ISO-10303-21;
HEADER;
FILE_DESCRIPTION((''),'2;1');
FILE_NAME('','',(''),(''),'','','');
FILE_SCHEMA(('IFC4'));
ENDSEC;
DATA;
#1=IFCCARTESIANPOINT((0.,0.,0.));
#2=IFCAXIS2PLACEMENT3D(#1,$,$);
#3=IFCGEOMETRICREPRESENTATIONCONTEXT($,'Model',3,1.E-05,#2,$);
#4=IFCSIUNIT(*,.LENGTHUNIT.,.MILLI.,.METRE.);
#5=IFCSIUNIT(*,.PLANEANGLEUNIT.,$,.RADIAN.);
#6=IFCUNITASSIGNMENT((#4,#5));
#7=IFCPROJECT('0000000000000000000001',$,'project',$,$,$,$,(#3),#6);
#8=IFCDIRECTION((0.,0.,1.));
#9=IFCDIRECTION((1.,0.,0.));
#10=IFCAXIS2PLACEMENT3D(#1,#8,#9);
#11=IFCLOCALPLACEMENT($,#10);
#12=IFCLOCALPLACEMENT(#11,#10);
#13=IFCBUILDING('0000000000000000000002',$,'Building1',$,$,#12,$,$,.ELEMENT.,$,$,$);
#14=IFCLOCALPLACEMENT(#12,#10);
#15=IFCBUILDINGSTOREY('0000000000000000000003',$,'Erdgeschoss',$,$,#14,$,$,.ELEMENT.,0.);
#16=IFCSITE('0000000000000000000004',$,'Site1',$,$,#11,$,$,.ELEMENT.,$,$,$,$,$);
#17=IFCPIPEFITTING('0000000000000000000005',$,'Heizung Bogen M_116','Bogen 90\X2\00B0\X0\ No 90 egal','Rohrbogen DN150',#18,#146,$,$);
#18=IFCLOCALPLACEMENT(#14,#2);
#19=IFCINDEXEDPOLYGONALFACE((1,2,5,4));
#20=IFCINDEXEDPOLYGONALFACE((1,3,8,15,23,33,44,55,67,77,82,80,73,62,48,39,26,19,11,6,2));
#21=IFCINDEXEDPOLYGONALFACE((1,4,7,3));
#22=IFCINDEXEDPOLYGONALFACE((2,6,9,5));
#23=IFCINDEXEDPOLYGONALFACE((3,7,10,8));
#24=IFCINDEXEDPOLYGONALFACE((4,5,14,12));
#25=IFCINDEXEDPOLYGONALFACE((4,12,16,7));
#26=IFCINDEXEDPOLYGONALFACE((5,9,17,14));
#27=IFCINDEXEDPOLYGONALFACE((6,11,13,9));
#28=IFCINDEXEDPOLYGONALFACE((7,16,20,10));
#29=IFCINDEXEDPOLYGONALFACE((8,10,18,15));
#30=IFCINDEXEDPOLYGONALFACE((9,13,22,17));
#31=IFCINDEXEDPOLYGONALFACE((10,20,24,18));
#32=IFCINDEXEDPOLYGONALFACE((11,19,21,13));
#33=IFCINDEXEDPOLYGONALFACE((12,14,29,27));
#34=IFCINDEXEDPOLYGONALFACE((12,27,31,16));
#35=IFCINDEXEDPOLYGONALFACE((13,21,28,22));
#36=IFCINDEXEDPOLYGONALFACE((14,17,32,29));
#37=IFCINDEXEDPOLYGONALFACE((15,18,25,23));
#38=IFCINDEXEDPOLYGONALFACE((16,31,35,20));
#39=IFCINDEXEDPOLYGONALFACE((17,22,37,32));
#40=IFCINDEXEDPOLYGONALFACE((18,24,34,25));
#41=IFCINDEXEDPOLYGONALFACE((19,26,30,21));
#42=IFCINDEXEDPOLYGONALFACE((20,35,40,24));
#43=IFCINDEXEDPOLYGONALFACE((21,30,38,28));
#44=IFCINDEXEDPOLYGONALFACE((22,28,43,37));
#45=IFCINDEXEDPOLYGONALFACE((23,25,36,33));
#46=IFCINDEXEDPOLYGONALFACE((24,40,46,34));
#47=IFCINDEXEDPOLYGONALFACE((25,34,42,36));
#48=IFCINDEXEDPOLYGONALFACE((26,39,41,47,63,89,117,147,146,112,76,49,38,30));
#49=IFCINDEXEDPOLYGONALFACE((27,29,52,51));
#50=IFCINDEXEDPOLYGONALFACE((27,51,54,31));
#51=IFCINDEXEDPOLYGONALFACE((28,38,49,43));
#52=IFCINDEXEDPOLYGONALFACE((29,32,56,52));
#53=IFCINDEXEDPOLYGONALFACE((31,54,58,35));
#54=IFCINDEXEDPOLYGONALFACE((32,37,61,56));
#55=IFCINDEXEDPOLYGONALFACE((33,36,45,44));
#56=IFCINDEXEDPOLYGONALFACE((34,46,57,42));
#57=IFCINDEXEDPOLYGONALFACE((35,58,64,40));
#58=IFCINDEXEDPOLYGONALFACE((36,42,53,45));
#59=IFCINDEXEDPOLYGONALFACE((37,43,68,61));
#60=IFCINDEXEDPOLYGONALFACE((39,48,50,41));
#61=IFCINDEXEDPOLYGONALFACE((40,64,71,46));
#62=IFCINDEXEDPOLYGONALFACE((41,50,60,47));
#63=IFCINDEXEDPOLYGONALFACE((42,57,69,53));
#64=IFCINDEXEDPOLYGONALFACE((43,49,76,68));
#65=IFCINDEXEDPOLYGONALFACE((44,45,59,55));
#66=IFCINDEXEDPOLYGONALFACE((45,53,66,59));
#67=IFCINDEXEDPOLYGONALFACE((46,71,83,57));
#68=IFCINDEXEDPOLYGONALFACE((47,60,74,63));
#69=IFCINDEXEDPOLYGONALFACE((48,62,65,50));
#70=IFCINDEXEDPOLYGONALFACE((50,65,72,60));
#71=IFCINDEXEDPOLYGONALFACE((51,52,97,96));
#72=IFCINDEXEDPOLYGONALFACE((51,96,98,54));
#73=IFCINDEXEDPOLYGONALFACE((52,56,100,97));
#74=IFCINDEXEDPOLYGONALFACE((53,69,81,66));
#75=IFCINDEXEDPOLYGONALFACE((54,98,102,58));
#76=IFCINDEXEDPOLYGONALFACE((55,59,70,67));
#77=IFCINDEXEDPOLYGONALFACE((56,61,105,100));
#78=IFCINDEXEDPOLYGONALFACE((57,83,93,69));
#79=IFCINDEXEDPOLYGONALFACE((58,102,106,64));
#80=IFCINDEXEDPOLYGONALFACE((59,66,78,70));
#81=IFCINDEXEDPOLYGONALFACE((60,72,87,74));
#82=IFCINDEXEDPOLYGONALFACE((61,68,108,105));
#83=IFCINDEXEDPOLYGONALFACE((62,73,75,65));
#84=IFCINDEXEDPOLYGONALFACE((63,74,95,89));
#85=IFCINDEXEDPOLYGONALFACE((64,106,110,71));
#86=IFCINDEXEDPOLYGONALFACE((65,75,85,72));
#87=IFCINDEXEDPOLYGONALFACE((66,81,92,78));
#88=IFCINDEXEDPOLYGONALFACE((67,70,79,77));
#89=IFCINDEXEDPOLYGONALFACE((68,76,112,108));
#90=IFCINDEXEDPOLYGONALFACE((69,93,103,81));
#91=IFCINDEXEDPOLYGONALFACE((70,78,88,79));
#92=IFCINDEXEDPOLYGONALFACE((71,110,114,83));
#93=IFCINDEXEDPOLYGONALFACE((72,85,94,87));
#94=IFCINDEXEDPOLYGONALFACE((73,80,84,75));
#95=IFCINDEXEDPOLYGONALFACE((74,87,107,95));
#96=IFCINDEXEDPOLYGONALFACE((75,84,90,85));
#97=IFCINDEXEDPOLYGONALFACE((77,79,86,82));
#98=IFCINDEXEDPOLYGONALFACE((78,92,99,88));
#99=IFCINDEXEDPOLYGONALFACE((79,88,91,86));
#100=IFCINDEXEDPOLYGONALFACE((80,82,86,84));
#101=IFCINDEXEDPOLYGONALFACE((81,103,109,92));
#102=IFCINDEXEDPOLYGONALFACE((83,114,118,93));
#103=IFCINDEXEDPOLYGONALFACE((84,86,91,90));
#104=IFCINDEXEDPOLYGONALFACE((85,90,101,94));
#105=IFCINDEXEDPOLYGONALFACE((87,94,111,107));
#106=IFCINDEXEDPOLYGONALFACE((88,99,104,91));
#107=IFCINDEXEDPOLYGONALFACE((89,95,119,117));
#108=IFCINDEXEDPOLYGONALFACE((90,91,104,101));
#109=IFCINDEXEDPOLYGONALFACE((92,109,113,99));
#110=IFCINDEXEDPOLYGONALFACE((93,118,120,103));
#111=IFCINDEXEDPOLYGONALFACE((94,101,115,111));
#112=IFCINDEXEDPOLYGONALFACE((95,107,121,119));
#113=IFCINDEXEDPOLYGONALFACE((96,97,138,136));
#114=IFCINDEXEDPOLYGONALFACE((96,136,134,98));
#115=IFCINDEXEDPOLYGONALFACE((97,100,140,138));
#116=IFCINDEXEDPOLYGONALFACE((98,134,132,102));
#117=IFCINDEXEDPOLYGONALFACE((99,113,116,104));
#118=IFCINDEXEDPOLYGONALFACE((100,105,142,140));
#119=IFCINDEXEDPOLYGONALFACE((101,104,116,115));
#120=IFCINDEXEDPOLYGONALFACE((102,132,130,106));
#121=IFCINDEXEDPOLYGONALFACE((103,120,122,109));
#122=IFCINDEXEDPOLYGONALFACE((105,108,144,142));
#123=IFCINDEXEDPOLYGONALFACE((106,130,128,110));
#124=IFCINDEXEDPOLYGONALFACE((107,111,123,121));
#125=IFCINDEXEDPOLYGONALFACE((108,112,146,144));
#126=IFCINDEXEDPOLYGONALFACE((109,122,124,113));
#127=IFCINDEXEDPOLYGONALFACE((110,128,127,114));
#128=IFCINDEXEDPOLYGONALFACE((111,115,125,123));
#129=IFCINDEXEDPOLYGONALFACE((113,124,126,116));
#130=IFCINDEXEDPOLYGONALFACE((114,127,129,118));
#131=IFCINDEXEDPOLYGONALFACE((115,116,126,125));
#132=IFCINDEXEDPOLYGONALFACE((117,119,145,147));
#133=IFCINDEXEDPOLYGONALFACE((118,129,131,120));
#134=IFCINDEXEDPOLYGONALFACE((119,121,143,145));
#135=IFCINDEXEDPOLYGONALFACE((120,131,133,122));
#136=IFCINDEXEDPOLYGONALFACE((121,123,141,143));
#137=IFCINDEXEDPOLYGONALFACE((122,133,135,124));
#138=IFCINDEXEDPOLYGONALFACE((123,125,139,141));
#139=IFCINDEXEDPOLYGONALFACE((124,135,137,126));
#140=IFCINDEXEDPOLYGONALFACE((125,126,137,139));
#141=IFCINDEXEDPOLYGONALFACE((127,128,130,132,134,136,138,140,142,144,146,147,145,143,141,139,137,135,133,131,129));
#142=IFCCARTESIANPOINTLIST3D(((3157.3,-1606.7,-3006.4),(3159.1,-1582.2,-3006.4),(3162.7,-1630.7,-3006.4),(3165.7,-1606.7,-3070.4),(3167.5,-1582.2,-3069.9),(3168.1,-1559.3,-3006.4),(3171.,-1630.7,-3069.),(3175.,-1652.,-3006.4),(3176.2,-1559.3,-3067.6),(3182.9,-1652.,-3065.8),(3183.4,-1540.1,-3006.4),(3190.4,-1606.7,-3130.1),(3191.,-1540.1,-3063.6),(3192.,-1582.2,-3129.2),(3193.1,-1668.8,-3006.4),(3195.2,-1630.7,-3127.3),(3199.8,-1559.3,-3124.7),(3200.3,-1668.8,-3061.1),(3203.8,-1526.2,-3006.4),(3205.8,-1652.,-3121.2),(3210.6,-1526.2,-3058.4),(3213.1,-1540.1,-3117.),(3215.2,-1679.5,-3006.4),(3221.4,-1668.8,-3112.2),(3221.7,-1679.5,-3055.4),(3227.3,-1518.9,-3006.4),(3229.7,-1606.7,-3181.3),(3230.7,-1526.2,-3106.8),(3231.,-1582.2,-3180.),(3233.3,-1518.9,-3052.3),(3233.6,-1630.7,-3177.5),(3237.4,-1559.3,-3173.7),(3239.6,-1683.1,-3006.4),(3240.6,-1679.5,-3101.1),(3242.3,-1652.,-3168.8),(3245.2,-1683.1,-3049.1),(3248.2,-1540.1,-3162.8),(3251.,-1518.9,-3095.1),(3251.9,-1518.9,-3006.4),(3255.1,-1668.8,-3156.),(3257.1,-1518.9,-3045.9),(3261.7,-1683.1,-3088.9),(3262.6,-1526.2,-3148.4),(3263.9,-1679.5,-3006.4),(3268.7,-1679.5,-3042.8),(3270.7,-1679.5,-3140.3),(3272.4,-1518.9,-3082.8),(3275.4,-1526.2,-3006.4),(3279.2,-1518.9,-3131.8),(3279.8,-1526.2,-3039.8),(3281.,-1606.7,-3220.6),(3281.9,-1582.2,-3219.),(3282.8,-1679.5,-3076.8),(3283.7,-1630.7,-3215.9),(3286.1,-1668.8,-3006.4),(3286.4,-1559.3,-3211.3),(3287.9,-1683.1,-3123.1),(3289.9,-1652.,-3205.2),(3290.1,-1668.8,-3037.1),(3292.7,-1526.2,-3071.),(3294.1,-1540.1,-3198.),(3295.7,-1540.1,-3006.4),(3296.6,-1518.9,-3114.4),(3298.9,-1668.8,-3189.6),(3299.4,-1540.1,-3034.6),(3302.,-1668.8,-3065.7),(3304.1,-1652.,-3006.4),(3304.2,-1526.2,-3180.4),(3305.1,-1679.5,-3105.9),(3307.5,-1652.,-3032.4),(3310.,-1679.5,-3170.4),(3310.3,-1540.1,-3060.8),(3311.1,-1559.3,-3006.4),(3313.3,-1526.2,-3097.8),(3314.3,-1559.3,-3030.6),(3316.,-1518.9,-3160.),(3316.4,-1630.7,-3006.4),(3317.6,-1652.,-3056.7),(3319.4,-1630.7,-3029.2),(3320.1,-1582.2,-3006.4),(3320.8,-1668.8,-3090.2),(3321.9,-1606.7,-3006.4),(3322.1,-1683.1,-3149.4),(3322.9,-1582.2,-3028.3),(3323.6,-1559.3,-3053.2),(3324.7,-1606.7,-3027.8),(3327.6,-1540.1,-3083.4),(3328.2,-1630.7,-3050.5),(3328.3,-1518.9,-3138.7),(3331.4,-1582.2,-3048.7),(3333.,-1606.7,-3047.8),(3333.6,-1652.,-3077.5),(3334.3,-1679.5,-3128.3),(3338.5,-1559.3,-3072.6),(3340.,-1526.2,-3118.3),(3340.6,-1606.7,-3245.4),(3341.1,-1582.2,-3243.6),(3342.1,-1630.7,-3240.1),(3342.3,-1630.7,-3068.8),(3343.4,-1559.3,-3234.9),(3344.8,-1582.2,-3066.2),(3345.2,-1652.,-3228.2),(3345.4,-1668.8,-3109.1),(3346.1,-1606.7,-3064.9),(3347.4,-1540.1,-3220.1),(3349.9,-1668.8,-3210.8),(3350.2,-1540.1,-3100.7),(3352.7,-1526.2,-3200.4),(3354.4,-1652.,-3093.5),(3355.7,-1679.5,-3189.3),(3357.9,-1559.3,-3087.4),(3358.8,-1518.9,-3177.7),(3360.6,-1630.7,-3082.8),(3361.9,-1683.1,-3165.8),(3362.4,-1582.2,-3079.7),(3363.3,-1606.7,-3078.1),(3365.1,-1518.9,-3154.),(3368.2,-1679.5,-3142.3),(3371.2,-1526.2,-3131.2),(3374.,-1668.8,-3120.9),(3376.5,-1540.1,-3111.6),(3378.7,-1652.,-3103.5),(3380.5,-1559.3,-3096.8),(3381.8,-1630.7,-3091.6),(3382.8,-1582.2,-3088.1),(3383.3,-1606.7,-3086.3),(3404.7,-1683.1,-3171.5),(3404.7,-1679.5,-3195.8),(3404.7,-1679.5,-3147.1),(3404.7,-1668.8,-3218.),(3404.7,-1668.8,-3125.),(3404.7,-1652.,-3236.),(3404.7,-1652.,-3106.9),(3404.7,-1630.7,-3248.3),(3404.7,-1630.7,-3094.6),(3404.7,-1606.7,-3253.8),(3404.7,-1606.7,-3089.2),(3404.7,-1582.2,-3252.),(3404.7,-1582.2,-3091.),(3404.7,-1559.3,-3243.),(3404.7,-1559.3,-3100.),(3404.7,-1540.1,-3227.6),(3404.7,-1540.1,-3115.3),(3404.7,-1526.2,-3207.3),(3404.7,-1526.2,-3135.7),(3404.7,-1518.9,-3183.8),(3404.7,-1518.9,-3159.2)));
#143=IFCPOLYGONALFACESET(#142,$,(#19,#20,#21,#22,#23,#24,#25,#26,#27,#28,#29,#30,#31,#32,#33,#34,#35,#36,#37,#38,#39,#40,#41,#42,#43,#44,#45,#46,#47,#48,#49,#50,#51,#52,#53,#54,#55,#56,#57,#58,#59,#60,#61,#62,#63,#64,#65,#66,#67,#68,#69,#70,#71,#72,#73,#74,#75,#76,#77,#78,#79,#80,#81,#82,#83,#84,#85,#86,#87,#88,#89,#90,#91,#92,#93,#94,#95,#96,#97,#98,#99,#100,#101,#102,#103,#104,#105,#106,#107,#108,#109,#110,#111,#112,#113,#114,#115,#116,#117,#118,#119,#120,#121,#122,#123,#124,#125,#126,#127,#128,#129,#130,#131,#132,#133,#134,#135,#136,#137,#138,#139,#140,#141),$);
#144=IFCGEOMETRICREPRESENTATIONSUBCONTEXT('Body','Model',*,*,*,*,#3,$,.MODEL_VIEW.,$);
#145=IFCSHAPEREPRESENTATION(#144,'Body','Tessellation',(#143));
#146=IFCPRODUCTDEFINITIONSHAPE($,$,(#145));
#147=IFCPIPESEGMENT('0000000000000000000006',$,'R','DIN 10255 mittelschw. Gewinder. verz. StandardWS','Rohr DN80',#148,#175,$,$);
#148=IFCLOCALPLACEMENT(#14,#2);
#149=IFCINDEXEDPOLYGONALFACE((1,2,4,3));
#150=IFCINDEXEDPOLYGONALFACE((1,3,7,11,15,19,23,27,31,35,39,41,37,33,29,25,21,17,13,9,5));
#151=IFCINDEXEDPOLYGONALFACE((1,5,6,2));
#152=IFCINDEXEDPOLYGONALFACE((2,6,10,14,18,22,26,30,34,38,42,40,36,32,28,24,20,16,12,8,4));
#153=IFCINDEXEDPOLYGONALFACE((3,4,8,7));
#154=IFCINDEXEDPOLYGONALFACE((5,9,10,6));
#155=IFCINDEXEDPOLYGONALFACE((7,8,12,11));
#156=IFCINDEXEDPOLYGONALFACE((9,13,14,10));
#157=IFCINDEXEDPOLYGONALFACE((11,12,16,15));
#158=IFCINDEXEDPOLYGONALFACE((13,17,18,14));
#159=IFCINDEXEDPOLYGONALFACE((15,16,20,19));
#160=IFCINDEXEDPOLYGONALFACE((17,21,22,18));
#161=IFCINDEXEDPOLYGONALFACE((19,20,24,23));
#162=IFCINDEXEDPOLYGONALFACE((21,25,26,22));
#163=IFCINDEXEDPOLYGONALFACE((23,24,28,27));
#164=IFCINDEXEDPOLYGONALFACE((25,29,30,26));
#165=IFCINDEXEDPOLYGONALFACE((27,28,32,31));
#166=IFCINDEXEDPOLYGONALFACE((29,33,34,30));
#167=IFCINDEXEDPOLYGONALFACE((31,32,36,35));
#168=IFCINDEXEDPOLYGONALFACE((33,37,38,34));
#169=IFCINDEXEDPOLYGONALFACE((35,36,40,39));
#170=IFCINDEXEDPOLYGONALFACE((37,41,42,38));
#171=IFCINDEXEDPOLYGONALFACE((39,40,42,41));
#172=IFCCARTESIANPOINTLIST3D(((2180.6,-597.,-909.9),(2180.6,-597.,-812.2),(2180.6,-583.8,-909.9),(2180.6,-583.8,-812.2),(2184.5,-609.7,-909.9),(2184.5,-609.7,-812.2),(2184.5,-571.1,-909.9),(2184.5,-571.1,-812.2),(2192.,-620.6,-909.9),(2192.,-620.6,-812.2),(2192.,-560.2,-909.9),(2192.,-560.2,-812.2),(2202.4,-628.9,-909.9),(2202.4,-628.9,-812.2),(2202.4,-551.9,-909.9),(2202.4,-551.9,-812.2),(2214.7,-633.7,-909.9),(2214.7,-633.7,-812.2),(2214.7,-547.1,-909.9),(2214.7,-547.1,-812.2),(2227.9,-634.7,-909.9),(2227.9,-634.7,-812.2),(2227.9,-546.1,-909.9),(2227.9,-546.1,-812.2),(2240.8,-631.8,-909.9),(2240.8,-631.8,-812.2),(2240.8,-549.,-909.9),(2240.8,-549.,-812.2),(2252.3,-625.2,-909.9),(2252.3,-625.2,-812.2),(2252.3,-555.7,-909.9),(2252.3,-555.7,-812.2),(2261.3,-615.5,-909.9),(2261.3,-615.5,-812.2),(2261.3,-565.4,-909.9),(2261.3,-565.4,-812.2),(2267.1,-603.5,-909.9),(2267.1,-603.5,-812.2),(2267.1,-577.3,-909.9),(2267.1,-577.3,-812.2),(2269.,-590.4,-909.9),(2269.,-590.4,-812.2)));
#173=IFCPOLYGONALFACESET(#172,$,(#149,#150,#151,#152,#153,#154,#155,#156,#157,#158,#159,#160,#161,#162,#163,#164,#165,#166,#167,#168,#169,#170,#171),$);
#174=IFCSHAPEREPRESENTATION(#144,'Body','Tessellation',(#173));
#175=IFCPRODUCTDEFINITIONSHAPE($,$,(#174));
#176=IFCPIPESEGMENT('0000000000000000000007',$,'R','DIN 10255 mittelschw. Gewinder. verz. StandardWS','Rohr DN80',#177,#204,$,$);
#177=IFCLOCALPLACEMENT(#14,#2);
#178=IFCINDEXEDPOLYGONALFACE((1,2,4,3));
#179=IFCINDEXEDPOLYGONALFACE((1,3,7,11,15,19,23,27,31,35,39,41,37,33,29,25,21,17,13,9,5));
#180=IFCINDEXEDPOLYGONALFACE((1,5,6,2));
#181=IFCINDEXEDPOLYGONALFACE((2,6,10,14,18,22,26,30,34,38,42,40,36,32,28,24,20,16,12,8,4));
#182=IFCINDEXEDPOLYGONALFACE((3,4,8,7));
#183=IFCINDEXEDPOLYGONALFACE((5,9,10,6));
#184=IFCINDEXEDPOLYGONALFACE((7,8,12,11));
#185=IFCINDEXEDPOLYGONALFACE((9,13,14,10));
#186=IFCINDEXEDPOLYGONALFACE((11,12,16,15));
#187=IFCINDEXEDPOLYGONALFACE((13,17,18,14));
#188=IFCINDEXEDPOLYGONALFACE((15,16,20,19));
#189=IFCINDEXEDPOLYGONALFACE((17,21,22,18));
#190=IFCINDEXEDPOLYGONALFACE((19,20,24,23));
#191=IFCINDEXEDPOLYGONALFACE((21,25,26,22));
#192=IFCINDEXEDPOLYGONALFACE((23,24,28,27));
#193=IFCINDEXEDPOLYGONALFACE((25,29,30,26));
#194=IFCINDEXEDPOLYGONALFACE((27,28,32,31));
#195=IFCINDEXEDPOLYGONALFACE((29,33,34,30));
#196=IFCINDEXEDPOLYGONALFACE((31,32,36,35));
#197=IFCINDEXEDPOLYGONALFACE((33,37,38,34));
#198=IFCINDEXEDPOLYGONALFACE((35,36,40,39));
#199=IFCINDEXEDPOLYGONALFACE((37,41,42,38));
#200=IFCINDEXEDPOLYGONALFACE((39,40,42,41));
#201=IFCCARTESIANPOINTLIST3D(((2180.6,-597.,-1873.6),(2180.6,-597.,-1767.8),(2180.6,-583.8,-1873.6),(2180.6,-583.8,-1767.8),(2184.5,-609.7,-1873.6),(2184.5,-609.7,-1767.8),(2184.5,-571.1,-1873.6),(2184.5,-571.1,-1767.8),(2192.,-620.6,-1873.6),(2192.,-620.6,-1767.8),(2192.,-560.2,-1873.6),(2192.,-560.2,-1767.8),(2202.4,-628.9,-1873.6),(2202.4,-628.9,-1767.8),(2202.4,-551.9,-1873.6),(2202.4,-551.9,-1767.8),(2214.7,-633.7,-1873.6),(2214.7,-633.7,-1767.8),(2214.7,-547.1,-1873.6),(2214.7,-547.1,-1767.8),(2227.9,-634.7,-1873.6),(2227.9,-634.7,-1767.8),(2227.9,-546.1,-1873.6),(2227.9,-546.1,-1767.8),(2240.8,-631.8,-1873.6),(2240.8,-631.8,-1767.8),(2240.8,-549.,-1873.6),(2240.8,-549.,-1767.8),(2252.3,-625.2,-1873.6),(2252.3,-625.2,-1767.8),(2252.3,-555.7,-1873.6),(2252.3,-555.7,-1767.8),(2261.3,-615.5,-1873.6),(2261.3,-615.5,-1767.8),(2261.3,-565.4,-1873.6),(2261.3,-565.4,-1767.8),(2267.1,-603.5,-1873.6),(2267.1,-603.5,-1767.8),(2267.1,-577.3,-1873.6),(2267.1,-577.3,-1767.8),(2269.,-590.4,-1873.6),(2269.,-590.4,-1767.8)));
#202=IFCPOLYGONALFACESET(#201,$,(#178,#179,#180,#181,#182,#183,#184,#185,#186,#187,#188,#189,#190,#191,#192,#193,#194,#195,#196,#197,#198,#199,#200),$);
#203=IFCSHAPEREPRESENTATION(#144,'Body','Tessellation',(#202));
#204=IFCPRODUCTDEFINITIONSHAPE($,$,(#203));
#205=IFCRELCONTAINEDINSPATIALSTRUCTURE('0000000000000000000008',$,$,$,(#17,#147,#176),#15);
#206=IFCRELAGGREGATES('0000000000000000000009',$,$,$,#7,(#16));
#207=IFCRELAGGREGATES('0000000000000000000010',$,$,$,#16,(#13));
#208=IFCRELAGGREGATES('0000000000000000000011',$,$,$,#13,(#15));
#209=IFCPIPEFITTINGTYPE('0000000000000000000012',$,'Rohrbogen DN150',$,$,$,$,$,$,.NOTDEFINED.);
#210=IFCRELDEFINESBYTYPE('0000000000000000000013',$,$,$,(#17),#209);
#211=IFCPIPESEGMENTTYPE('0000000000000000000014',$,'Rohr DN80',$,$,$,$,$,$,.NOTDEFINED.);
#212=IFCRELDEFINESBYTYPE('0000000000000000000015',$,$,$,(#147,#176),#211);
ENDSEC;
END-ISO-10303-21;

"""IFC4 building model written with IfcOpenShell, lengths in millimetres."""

from ifc_helpers import new_model, entity, si_unit, frame, origin, origin_with_axes, origin_2d_with_axis, place, context, subcontext, project, spatial, circle, extrude, source, transform, mapped, type_object, element, save


model = new_model("IFC4")

# Units and contexts
model_context = context("Model", 3, precision=1e-05, world=origin())
body_context = subcontext(model_context, "Body", "Model", "MODEL_VIEW")
ifc_project = project(units=[si_unit("LENGTHUNIT", "METRE", prefix="MILLI"), si_unit("PLANEANGLEUNIT", "RADIAN")], contexts=[model_context])

# Site, building, storey
site_placement = place(None, origin_with_axes())
site = spatial("IfcSite", under=ifc_project, at=site_placement, Name="Site1", CompositionType="ELEMENT")
building_placement = place(site_placement, origin_with_axes())
building = spatial("IfcBuilding", under=site, at=building_placement, Name="Building1", CompositionType="ELEMENT")
storey_placement = place(building_placement, origin_with_axes())
storey = spatial("IfcBuildingStorey", under=building, at=storey_placement, Name="Erdgeschoss", CompositionType="ELEMENT", Elevation=0.0)

# Pipe fitting
pipe_fitting_type_1 = type_object("IfcPipeFittingType", Name="Rohrbogen DN150", PredefinedType="NOTDEFINED")
shared_shape_1 = source(origin_with_axes(), body_context, "Body", "SolidModel", [
    entity("IfcRevolvedAreaSolid", entity("IfcCircleProfileDef", "AREA", None, entity("IfcAxis2Placement2D", entity("IfcCartesianPoint", [0.0, 0.0]), entity("IfcDirection", [1.0, 0.0])), 82.5), entity("IfcAxis2Placement3D", entity("IfcCartesianPoint", [123.8, 41.3, 0.0]), entity("IfcDirection", [-1.0, 0.0, 0.0]), entity("IfcDirection", [0.0, 0.0, -1.0])), entity("IfcAxis1Placement", entity("IfcCartesianPoint", [0.0, 165.1, 0.0]), entity("IfcDirection", [-1.0, 0.0, 0.0])), 1.570796),
])
pipe_fitting_1_placement = place(storey_placement, frame((3280.9, -1600.6, -3130.2), z_axis=(0.0, 0.0, 1.0), x_axis=(1.0, 0.0, 0.0)))
element("IfcPipeFitting", 1, at=pipe_fitting_1_placement, inside=storey, type_object=pipe_fitting_type_1, Name="Heizung Bogen M_116", Description="Bogen 90° No 90 egal", ObjectType="Rohrbogen DN150", context=body_context, shape_type="MappedRepresentation", body=[
    mapped(shared_shape_1, transform((0.0, 0.0, 0.0), x_axis=(1.0, 0.0, 0.0), y_axis=(0.0, 0.0, -1.0), z_axis=(0.0, 1.0, 0.0), scale=1.0)),
])

# Pipe segments
pipe_segment_type_1 = type_object("IfcPipeSegmentType", Name="Rohr DN80", PredefinedType="NOTDEFINED")
pipe_segment_1_placement = place(storey_placement, frame((2224.6, -590.6, -861.0), z_axis=(0.0, 0.0, 1.0), x_axis=(1.0, 0.0, 0.0)))
element("IfcPipeSegment", 2, at=pipe_segment_1_placement, inside=storey, type_object=pipe_segment_type_1, Name="R", Description="DIN 10255 mittelschw. Gewinder. verz. StandardWS", ObjectType="Rohr DN80", context=body_context, shape_type="SolidModel", body=[
    extrude(circle(Radius=44.5, at=origin_2d_with_axis()), frame((0.0, 0.1, -48.8), z_axis=(0.0, 0.0, 1.0), x_axis=(1.0, 0.0, 0.0)), (0.0, 0.0, 1.0), 97.7),
])
pipe_segment_2_placement = place(storey_placement, frame((2224.6, -590.6, -1820.7), z_axis=(0.0, 0.0, 1.0), x_axis=(1.0, 0.0, 0.0)))
element("IfcPipeSegment", 3, at=pipe_segment_2_placement, inside=storey, type_object=pipe_segment_type_1, Name="R", Description="DIN 10255 mittelschw. Gewinder. verz. StandardWS", ObjectType="Rohr DN80", context=body_context, shape_type="SolidModel", body=[
    extrude(circle(Radius=44.5, at=origin_2d_with_axis()), frame((0.0, 0.1, -52.9), z_axis=(0.0, 0.0, 1.0), x_axis=(1.0, 0.0, 0.0)), (0.0, 0.0, 1.0), 105.8),
])

save(model, "model.ifc")
